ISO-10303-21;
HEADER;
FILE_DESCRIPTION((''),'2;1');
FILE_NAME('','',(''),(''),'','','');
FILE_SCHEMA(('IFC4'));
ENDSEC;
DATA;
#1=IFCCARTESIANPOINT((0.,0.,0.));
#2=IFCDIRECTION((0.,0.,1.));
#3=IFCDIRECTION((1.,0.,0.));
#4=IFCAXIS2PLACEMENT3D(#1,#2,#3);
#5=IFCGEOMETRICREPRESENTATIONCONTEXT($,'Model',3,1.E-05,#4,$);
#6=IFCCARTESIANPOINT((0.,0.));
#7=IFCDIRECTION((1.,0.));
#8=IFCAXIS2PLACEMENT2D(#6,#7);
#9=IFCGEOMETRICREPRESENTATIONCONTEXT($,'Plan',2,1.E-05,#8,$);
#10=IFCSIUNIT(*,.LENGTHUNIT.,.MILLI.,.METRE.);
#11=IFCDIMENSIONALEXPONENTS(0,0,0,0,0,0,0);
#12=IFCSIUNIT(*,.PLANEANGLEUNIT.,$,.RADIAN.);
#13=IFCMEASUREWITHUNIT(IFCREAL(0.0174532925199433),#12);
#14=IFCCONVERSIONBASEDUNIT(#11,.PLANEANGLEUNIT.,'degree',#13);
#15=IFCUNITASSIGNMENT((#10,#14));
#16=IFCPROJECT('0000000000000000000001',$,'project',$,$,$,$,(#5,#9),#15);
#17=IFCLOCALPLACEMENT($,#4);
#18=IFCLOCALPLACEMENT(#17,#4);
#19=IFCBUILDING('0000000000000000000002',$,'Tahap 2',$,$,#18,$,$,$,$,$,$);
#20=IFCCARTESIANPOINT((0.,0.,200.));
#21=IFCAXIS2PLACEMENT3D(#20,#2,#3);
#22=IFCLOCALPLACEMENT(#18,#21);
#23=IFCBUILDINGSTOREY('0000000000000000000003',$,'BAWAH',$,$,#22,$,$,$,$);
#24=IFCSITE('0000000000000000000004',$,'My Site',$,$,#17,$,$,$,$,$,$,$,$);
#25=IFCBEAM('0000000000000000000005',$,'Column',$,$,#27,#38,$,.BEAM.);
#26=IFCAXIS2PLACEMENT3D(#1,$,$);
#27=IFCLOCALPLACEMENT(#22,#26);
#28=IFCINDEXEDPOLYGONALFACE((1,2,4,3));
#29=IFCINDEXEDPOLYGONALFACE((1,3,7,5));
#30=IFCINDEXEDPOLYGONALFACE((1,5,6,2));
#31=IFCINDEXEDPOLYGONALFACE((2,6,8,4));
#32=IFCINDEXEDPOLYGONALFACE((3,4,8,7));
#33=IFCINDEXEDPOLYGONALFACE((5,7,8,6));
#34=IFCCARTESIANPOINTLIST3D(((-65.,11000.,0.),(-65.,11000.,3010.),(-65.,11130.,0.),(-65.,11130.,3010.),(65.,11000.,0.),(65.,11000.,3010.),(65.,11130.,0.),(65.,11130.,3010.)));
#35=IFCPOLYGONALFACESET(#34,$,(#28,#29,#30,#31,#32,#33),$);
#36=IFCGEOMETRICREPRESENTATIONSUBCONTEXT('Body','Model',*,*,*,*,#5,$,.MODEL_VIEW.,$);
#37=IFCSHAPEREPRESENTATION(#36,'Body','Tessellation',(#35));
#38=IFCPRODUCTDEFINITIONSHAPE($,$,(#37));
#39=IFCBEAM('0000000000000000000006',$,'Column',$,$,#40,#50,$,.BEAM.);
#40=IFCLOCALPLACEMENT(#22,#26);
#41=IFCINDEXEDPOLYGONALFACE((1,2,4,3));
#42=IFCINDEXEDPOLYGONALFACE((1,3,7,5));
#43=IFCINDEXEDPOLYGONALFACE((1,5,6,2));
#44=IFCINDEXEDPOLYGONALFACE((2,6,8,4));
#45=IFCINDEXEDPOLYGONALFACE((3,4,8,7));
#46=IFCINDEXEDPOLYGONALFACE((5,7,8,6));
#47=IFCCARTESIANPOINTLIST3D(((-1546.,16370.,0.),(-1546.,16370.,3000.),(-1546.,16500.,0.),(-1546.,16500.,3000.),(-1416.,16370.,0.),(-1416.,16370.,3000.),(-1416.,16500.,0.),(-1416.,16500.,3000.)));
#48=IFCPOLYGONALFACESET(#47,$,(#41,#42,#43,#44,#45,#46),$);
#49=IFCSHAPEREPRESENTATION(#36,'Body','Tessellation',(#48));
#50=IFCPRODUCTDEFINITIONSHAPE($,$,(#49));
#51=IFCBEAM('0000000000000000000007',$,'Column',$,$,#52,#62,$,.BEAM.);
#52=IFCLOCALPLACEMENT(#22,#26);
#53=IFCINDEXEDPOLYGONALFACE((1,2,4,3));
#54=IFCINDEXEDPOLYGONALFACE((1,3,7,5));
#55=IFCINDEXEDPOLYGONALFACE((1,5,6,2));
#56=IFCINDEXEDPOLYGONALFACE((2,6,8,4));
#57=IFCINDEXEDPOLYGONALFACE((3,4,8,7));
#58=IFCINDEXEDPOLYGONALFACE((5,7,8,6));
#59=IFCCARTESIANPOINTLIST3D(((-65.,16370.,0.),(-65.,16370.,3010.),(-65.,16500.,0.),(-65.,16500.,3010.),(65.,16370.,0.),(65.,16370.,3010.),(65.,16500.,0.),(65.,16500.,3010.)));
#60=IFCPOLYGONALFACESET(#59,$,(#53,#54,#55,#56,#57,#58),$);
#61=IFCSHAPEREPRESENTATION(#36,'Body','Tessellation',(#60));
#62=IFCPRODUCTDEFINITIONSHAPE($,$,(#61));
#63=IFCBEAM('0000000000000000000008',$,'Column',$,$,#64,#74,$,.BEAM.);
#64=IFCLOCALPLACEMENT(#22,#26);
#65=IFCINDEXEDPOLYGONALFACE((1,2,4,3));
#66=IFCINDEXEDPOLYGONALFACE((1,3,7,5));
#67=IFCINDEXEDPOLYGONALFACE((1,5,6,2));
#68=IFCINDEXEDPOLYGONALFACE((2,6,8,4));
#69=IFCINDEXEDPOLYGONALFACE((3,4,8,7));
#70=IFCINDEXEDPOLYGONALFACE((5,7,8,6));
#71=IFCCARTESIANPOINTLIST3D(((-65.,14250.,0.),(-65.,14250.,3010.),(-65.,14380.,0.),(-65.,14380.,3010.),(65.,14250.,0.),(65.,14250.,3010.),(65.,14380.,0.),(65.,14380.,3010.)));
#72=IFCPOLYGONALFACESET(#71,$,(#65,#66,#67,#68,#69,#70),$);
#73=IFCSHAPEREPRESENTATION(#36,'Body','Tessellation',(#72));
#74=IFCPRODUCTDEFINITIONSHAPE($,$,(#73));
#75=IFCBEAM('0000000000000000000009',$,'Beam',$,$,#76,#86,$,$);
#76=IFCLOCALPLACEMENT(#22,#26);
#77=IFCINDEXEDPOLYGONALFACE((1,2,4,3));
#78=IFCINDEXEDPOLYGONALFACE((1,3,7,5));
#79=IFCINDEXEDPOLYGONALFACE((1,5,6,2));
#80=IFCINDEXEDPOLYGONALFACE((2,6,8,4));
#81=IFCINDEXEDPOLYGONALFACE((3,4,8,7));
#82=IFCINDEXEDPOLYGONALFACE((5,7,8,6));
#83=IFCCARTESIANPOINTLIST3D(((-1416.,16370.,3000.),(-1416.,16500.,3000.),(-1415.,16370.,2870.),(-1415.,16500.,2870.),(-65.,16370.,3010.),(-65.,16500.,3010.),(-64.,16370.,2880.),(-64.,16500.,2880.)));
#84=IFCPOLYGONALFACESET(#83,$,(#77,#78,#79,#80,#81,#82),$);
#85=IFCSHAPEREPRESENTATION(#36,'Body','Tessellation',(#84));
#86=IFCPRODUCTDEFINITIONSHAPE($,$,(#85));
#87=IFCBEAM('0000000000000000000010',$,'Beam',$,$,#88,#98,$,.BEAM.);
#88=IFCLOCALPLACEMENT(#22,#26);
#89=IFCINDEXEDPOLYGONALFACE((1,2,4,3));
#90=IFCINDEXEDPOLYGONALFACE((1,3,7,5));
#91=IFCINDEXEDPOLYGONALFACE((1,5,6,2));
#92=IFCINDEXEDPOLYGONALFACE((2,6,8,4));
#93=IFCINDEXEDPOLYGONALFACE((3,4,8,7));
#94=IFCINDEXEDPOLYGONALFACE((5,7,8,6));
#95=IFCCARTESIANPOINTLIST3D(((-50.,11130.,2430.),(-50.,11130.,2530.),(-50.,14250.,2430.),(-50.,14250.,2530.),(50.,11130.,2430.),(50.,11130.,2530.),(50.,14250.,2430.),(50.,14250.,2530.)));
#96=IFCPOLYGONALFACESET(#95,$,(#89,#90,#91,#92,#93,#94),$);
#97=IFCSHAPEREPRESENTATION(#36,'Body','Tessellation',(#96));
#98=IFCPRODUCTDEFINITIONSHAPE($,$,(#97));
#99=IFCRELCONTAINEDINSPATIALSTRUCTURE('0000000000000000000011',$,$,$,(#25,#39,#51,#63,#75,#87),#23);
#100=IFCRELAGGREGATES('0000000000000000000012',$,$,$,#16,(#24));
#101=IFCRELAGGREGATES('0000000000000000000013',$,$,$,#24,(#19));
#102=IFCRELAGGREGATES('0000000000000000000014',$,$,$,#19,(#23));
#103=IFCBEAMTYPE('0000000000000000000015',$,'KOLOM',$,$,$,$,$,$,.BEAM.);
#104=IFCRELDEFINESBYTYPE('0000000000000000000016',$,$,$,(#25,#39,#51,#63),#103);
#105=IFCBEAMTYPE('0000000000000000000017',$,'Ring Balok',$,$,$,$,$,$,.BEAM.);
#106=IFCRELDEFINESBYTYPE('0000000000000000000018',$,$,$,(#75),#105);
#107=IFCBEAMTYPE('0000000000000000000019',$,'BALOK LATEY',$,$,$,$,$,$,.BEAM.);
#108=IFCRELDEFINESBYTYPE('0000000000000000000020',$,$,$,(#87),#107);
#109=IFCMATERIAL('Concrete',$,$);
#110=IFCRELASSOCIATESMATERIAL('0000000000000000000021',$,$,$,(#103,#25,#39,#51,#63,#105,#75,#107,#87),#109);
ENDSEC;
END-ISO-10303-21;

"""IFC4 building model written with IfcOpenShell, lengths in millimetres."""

from ifc_helpers import new_model, entity, si_unit, converted_unit, frame, origin_with_axes, origin_2d_with_axis, place, context, subcontext, project, spatial, rectangle, extrude, material, material_profile, profile_set, profile_usage, type_object, element, save


model = new_model("IFC4")

# Units and contexts
model_context = context("Model", 3, precision=1e-05, world=origin_with_axes())
plan_context = context("Plan", 2, precision=1e-05, world=origin_2d_with_axis())
body_context = subcontext(model_context, "Body", "Model", "MODEL_VIEW")
ifc_project = project(units=[si_unit("LENGTHUNIT", "METRE", prefix="MILLI"), converted_unit("PLANEANGLEUNIT", "degree", entity("IfcReal", 0.0174532925199433), si_unit("PLANEANGLEUNIT", "RADIAN"), dimensions=[0, 0, 0, 0, 0, 0, 0])], contexts=[model_context, plan_context])

# Site, building, storey
site_placement = place(None, origin_with_axes())
site = spatial("IfcSite", under=ifc_project, at=site_placement, Name="My Site")
building_placement = place(site_placement, origin_with_axes())
building = spatial("IfcBuilding", under=site, at=building_placement, Name="Tahap 2")
storey_placement = place(building_placement, frame((0.0, 0.0, 200.0), z_axis=(0.0, 0.0, 1.0), x_axis=(1.0, 0.0, 0.0)))
storey = spatial("IfcBuildingStorey", under=building, at=storey_placement, Name="BAWAH")

# Beams
ifc_material_1 = material(Name="Concrete")
ifc_material_profile_1 = material_profile(ifc_material_1, rectangle(XDim=130.0, YDim=130.0, kind="CURVE"))
ifc_profile_set_1 = profile_set([ifc_material_profile_1])
ifc_profile_usage_1 = profile_usage(ifc_profile_set_1, cardinal=5)
beam_type_1 = type_object("IfcBeamType", Name="KOLOM", PredefinedType="BEAM", material=ifc_profile_set_1)
beam_1_placement = place(storey_placement, frame((0.0, 11065.0, 0.0), z_axis=(0.0, 0.0, 1.0), x_axis=(1.0, 0.0, 0.0)))
element("IfcBeam", 1, at=beam_1_placement, inside=storey, type_object=beam_type_1, material=ifc_profile_usage_1, Name="Column", PredefinedType="BEAM", context=body_context, shape_type="SweptSolid", body=[
    extrude(rectangle(XDim=130.0, YDim=130.0, kind="CURVE"), origin_with_axes(), (0.0, 0.0, 1.0), 3010.0),
])
ifc_profile_usage_2 = profile_usage(ifc_profile_set_1, cardinal=2)
beam_2_placement = place(storey_placement, frame((-1481.0, 16370.0, 0.0), z_axis=(0.0, 0.0, 1.0), x_axis=(1.0, 0.0, 0.0)))
element("IfcBeam", 2, at=beam_2_placement, inside=storey, type_object=beam_type_1, material=ifc_profile_usage_2, Name="Column", PredefinedType="BEAM", context=body_context, shape_type="SweptSolid", body=[
    extrude(rectangle(XDim=130.0, YDim=130.0, kind="CURVE"), frame((0.0, 65.0, 0.0), z_axis=(0.0, 0.0, 1.0), x_axis=(1.0, 0.0, 0.0)), (0.0, 0.0, 1.0), 3000.0),
])
ifc_profile_usage_3 = profile_usage(ifc_profile_set_1, cardinal=2)
beam_3_placement = place(storey_placement, frame((0.0, 16370.0, 0.0), z_axis=(0.0, 0.0, 1.0), x_axis=(1.0, 0.0, 0.0)))
element("IfcBeam", 3, at=beam_3_placement, inside=storey, type_object=beam_type_1, material=ifc_profile_usage_3, Name="Column", PredefinedType="BEAM", context=body_context, shape_type="SweptSolid", body=[
    extrude(rectangle(XDim=130.0, YDim=130.0, kind="CURVE"), frame((0.0, 65.0, 0.0), z_axis=(0.0, 0.0, 1.0), x_axis=(1.0, 0.0, 0.0)), (0.0, 0.0, 1.0), 3010.0),
])
ifc_profile_usage_4 = profile_usage(ifc_profile_set_1, cardinal=5)
beam_4_placement = place(storey_placement, frame((0.0, 14315.0, 0.0), z_axis=(0.0, 0.0, 1.0), x_axis=(1.0, 0.0, 0.0)))
element("IfcBeam", 4, at=beam_4_placement, inside=storey, type_object=beam_type_1, material=ifc_profile_usage_4, Name="Column", PredefinedType="BEAM", context=body_context, shape_type="SweptSolid", body=[
    extrude(rectangle(XDim=130.0, YDim=130.0, kind="CURVE"), origin_with_axes(), (0.0, 0.0, 1.0), 3010.0),
])
ifc_material_profile_2 = material_profile(ifc_material_1, rectangle(XDim=130.0, YDim=130.0))
ifc_profile_set_2 = profile_set([ifc_material_profile_2])
ifc_profile_usage_5 = profile_usage(ifc_profile_set_2, cardinal=9)
beam_type_2 = type_object("IfcBeamType", Name="Ring Balok", PredefinedType="BEAM", material=ifc_profile_set_2)
beam_5_placement = place(storey_placement, frame((-1416.0, 16370.0, 3000.0), z_axis=(0.999973, 0.0, 0.007409), x_axis=(0.0, 1.0, 0.0)))
element("IfcBeam", 5, at=beam_5_placement, inside=storey, type_object=beam_type_2, material=ifc_profile_usage_5, Name="Beam", context=body_context, shape_type="SweptSolid", body=[
    extrude(rectangle(XDim=130.0, YDim=130.0), frame((65.0, -65.0, 0.0), z_axis=(0.0, 0.0, 1.0), x_axis=(1.0, 0.0, 0.0)), (0.0, 0.0, 1.0), 1351.0),
])

# Beam
ifc_material_profile_3 = material_profile(ifc_material_1, rectangle(XDim=100.0, YDim=100.0))
ifc_profile_set_3 = profile_set([ifc_material_profile_3])
ifc_profile_usage_6 = profile_usage(ifc_profile_set_3, cardinal=2)
beam_type_3 = type_object("IfcBeamType", Name="BALOK LATEY", PredefinedType="BEAM", material=ifc_profile_set_3)
beam_6_placement = place(storey_placement, frame((0.0, 11130.0, 2430.0), z_axis=(0.0, 1.0, 0.0), x_axis=(-1.0, 0.0, 0.0)))
element("IfcBeam", 6, at=beam_6_placement, inside=storey, type_object=beam_type_3, material=ifc_profile_usage_6, Name="Beam", PredefinedType="BEAM", context=body_context, shape_type="SweptSolid", body=[
    extrude(rectangle(XDim=100.0, YDim=100.0), frame((0.0, 50.0, 0.0), z_axis=(0.0, 0.0, 1.0), x_axis=(1.0, 0.0, 0.0)), (0.0, 0.0, 1.0), 3120.0),
])

save(model, "model.ifc")
